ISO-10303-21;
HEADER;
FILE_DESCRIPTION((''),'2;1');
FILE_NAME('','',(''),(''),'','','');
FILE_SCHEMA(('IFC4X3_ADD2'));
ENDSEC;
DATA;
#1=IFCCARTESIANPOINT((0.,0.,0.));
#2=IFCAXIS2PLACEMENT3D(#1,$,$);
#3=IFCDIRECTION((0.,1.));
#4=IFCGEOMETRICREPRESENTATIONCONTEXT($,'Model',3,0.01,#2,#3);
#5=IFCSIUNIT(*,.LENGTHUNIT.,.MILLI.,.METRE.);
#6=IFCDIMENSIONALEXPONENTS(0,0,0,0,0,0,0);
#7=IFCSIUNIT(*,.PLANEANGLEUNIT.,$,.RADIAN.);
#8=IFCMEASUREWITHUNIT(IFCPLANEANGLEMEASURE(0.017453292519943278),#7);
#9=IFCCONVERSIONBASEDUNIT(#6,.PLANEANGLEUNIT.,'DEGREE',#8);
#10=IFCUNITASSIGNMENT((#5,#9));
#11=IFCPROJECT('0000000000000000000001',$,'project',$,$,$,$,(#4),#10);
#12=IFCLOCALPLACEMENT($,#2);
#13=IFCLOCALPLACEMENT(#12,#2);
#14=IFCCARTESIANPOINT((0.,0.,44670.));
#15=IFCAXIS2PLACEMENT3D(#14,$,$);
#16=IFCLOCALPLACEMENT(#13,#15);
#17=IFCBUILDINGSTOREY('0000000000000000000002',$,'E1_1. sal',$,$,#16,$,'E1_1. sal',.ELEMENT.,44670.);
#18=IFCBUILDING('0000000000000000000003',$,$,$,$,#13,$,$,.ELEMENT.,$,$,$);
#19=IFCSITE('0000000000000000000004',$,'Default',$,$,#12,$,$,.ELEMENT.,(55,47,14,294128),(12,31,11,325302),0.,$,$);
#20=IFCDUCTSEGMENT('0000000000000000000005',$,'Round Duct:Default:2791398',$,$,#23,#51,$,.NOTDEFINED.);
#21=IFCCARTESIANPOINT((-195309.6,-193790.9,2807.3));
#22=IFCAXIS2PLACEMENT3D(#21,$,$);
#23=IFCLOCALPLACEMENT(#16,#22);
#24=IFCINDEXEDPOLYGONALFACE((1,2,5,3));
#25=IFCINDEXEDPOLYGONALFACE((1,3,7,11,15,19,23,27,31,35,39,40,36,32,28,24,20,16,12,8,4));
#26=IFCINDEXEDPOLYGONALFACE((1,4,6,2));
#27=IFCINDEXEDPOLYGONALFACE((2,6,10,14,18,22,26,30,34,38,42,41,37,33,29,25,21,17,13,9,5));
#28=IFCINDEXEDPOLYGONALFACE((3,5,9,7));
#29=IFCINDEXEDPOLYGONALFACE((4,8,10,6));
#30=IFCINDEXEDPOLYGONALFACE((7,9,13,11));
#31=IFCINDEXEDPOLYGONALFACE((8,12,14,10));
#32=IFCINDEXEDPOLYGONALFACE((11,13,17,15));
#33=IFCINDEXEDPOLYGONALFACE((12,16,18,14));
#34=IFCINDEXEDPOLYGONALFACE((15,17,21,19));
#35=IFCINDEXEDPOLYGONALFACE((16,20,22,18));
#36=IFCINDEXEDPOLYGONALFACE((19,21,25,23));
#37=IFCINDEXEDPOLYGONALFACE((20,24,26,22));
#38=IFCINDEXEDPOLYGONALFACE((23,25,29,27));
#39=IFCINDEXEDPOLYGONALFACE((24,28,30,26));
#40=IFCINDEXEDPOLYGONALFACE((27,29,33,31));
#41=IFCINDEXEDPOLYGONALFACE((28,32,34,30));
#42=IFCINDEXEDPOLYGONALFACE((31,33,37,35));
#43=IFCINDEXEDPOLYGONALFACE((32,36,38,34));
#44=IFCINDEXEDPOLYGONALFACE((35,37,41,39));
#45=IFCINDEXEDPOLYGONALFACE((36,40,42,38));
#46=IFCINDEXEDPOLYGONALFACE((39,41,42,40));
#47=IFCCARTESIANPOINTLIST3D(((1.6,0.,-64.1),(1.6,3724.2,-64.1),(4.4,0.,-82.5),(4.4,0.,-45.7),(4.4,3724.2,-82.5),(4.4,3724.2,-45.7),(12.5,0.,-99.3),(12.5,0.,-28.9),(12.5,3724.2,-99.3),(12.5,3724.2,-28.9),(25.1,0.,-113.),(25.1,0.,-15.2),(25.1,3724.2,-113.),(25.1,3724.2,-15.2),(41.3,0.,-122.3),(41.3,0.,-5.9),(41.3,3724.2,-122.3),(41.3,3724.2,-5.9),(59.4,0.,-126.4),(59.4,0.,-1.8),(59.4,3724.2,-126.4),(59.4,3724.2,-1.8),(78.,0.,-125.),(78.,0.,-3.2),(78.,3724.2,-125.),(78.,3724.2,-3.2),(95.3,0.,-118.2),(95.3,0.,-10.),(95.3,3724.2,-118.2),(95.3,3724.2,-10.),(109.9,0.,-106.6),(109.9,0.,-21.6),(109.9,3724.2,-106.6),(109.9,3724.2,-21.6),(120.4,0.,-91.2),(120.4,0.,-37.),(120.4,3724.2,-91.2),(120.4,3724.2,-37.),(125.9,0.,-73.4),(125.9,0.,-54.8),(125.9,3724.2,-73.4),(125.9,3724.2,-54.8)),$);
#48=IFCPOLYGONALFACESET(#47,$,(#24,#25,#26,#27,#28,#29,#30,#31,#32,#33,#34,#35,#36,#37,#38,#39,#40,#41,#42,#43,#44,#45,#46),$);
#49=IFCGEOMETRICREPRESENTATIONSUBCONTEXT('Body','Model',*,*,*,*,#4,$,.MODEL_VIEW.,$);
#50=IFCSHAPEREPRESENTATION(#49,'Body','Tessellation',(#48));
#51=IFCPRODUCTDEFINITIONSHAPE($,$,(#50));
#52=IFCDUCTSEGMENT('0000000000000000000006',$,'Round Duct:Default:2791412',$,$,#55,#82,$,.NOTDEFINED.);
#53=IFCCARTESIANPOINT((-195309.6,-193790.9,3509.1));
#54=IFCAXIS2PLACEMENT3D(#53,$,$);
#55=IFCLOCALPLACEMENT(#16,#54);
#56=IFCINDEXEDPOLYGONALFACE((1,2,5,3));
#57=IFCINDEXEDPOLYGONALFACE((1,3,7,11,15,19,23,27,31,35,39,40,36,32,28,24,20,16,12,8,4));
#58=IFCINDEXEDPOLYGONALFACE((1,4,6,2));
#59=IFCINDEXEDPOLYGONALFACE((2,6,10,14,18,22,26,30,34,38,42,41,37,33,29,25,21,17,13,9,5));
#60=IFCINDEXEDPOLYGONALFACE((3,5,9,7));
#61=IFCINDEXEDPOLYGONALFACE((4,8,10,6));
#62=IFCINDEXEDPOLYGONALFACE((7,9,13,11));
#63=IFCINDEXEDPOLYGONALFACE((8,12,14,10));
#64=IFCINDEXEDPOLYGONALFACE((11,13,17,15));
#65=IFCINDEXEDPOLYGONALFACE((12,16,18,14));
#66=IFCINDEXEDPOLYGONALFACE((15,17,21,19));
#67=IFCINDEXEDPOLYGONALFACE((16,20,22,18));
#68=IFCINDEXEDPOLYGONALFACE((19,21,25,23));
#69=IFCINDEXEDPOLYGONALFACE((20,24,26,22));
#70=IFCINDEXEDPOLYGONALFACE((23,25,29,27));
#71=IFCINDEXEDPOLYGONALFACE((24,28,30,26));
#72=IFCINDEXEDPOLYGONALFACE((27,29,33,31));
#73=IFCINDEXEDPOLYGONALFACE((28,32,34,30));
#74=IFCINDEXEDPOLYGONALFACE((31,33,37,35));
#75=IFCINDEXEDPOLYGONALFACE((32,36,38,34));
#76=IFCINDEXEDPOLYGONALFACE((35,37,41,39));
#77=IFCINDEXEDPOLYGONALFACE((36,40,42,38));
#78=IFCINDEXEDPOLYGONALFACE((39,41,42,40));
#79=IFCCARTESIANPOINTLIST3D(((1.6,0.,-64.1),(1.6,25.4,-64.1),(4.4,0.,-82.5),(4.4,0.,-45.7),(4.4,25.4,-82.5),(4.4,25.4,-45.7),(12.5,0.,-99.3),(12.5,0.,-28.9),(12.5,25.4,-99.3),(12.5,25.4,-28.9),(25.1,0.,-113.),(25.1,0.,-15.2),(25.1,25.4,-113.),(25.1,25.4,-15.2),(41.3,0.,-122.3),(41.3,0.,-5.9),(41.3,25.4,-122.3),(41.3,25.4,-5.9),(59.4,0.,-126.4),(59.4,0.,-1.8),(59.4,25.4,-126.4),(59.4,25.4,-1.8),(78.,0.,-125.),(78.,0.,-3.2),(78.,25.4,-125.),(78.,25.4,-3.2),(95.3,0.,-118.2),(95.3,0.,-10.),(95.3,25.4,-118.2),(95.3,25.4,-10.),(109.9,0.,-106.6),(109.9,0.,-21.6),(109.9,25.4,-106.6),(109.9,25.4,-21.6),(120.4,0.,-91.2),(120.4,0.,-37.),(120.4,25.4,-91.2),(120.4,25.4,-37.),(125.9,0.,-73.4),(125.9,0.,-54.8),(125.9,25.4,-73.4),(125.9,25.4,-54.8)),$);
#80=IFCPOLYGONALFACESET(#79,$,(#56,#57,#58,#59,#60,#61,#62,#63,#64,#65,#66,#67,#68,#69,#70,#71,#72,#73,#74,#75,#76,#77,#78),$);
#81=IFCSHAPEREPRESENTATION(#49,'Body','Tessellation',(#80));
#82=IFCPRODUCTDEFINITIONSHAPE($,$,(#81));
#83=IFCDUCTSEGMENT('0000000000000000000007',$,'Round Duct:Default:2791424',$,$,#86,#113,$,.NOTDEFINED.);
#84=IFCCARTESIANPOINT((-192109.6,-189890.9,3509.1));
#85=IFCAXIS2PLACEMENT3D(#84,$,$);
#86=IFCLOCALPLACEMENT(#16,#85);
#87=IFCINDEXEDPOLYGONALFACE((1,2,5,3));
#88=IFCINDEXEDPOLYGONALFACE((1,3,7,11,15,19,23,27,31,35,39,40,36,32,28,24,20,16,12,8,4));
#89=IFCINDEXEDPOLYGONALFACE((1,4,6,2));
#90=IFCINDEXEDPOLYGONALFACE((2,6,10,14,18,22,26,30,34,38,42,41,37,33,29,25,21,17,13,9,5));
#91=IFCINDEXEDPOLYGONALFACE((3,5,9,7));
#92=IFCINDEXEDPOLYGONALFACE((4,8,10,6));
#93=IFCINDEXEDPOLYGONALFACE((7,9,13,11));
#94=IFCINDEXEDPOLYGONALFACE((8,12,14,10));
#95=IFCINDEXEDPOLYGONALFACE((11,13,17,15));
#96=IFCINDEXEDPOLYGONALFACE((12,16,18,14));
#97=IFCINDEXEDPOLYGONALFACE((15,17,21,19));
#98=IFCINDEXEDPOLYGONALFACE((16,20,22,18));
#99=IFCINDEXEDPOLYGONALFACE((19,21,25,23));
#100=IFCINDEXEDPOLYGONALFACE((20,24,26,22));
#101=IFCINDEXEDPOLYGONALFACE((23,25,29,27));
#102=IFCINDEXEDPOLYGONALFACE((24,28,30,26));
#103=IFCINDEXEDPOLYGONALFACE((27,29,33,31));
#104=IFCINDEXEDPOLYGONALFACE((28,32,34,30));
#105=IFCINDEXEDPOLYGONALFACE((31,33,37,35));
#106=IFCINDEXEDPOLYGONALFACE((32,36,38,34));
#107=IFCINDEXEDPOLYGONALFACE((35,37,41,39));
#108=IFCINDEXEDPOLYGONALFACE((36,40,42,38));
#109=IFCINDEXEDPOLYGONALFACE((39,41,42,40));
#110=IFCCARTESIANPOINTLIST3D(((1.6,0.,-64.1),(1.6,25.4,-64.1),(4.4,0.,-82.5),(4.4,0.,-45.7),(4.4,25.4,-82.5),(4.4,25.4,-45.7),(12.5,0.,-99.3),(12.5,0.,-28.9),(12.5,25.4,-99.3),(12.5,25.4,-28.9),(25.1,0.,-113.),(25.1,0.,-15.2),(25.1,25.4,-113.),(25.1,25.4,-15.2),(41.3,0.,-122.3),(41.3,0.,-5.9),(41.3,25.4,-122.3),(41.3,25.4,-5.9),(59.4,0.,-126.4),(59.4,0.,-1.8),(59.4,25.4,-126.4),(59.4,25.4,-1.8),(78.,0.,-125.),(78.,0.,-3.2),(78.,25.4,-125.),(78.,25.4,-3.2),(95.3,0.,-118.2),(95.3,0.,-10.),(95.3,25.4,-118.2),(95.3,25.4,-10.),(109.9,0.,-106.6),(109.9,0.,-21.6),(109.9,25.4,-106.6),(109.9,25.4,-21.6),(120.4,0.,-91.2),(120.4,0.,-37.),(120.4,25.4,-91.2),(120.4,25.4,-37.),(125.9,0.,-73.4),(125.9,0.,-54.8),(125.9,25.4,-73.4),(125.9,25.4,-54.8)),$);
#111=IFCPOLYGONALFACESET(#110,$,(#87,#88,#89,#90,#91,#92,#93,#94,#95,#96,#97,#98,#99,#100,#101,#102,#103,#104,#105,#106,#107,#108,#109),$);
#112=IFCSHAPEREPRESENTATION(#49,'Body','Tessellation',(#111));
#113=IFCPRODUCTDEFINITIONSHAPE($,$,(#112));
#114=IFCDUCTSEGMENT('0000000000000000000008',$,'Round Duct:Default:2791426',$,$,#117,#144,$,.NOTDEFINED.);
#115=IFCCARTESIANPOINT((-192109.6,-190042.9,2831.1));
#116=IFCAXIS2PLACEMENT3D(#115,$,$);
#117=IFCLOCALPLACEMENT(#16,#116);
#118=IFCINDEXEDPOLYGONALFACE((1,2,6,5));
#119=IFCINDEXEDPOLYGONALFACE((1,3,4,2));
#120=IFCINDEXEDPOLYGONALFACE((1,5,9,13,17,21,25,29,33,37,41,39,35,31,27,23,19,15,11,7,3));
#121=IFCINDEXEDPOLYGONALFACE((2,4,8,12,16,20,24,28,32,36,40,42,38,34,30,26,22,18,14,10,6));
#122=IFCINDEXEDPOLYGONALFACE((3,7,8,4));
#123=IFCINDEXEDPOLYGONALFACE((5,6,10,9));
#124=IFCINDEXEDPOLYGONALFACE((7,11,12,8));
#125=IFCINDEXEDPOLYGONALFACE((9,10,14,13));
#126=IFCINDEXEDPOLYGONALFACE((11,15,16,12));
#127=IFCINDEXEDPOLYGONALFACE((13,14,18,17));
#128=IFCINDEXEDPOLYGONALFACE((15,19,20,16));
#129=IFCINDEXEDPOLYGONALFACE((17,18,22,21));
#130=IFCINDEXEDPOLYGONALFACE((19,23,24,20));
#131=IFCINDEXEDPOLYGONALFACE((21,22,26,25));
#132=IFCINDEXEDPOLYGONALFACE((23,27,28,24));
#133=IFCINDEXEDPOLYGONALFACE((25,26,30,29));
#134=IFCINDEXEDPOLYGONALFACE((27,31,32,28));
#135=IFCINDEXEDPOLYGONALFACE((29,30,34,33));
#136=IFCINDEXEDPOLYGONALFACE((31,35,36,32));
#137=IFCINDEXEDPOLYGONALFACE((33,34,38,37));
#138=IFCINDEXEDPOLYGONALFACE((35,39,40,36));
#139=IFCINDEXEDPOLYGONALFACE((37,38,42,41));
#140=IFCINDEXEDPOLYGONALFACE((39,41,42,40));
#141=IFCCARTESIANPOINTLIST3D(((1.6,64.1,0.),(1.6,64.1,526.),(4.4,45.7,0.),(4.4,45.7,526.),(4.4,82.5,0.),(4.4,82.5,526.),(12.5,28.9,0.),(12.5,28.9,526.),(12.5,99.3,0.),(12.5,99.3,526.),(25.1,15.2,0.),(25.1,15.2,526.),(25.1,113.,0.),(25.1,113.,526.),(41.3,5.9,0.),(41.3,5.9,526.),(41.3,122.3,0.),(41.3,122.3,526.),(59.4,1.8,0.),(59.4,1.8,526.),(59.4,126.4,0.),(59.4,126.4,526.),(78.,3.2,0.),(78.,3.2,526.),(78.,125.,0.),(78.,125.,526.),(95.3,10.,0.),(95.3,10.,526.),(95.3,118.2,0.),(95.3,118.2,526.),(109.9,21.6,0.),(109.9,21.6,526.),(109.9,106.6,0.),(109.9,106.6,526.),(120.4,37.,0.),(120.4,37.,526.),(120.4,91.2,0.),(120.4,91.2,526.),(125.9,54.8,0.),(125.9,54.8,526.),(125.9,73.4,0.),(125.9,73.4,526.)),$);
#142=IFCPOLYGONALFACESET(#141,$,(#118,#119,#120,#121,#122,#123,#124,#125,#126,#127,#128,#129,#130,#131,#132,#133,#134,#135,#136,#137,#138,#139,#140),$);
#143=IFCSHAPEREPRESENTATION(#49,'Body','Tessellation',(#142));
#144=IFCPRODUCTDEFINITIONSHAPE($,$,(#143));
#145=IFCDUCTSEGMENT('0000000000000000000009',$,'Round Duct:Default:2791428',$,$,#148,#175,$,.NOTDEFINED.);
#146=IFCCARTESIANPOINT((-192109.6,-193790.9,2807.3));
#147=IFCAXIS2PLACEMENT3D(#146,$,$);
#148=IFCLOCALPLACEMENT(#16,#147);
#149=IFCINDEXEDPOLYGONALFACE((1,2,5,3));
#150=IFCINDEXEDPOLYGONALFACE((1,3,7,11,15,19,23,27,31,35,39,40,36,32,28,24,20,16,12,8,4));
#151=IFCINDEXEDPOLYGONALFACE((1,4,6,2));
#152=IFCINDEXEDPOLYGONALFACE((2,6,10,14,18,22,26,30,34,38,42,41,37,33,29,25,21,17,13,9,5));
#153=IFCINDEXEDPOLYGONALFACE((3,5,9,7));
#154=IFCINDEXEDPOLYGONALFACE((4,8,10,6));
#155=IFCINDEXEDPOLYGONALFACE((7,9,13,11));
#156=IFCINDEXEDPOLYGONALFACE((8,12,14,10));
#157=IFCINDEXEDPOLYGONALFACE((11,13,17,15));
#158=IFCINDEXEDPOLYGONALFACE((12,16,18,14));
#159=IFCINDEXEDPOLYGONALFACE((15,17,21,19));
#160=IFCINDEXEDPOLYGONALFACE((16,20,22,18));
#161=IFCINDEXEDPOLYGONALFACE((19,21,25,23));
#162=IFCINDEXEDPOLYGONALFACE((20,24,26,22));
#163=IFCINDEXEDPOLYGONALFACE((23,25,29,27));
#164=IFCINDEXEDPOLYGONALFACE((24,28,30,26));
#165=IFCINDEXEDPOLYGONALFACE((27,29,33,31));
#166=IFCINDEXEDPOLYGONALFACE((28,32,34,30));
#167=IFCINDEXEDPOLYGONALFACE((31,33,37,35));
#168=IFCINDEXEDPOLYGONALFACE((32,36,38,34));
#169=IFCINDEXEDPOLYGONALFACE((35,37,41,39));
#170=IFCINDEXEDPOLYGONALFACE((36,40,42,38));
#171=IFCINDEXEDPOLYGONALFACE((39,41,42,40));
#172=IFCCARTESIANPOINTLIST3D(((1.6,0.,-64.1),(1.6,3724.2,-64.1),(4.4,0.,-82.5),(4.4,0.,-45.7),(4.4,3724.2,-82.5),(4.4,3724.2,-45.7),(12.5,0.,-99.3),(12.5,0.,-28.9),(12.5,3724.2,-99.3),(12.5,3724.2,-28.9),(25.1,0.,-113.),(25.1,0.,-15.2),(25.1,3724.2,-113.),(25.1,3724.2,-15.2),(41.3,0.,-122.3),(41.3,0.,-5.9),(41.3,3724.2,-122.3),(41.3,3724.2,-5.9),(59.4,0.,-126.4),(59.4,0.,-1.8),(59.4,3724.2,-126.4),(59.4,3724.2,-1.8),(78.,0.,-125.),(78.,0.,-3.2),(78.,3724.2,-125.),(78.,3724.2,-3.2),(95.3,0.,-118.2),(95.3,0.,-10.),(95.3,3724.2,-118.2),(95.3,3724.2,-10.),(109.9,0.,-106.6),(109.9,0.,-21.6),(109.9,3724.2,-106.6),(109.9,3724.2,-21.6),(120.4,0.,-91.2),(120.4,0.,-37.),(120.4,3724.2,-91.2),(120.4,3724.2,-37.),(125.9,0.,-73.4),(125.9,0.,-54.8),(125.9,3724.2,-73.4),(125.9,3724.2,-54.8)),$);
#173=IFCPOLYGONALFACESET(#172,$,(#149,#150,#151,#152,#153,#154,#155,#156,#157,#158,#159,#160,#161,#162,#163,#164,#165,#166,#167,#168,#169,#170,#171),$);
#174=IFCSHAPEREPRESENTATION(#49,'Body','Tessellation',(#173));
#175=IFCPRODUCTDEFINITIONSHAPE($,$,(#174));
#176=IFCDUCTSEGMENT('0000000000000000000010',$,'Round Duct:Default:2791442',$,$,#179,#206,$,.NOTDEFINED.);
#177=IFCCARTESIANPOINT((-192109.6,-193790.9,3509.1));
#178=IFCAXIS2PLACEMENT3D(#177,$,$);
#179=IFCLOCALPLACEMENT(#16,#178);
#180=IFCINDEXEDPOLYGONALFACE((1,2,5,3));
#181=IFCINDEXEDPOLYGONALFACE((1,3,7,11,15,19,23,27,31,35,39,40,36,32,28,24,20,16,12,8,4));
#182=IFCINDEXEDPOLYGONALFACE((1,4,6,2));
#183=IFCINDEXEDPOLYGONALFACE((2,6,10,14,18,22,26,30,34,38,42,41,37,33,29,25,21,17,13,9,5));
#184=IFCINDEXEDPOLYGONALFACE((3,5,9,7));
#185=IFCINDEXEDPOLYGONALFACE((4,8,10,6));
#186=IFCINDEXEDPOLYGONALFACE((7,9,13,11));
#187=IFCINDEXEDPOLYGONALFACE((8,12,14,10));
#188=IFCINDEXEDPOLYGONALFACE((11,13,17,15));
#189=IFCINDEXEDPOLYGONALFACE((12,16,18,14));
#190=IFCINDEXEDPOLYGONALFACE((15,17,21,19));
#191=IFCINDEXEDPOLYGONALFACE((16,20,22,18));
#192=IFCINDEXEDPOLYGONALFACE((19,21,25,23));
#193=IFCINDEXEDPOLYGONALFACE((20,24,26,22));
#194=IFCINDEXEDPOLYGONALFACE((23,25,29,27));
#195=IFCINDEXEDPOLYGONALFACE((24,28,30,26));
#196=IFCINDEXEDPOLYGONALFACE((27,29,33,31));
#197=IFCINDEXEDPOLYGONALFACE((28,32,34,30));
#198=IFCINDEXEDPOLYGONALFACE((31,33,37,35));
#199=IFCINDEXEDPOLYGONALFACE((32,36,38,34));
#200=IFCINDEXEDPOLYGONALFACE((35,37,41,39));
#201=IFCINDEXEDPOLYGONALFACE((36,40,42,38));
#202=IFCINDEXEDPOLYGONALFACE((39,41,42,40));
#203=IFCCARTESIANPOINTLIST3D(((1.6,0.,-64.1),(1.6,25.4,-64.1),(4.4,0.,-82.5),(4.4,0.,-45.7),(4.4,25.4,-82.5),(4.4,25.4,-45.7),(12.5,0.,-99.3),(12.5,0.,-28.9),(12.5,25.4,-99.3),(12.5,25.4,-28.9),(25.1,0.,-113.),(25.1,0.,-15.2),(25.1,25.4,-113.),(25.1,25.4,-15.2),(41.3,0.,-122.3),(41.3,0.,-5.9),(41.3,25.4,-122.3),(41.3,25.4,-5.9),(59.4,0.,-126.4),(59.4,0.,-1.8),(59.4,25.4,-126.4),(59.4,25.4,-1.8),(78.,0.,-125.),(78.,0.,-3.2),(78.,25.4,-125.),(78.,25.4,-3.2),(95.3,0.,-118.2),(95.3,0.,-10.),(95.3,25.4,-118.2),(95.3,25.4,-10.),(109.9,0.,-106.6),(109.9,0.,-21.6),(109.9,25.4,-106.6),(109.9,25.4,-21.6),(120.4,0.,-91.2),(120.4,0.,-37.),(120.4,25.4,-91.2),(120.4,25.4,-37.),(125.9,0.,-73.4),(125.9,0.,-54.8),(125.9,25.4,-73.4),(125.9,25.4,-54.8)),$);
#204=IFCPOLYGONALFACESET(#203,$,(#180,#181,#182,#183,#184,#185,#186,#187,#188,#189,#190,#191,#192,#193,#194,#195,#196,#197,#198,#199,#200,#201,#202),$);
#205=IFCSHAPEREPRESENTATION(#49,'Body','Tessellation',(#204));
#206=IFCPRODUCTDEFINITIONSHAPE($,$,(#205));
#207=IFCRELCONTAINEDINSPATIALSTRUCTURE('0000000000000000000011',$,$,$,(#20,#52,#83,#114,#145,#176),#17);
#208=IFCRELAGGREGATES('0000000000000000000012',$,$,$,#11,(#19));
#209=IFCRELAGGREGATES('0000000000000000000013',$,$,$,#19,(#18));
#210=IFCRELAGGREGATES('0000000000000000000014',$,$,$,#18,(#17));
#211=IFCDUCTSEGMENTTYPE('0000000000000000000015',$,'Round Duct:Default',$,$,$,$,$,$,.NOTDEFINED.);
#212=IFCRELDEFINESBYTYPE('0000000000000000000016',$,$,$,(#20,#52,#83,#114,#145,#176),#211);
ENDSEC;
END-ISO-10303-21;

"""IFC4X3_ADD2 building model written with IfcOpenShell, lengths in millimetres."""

from ifc_helpers import new_model, entity, si_unit, converted_unit, direction, frame, frame_2d, origin, origin_2d_with_axis, place, context, subcontext, project, spatial, circle, extrude, type_object, element, save


model = new_model("IFC4X3_ADD2")

# Units and contexts
model_context = context("Model", 3, precision=0.01, world=origin(), true_north=direction((0.0, 1.0)))
body_context = subcontext(model_context, "Body", "Model", "MODEL_VIEW")
ifc_project = project(units=[si_unit("LENGTHUNIT", "METRE", prefix="MILLI"), converted_unit("PLANEANGLEUNIT", "DEGREE", entity("IfcPlaneAngleMeasure", 0.017453292519943278), si_unit("PLANEANGLEUNIT", "RADIAN"), dimensions=[0, 0, 0, 0, 0, 0, 0])], contexts=[model_context])

# Site, building, storey
site_placement = place(None, origin())
site = spatial("IfcSite", under=ifc_project, at=site_placement, Name="Default", CompositionType="ELEMENT", RefLatitude=(55, 47, 14, 294128), RefLongitude=(12, 31, 11, 325302), RefElevation=0.0)
building_placement = place(site_placement, origin())
building = spatial("IfcBuilding", under=site, at=building_placement, CompositionType="ELEMENT")
storey_placement = place(building_placement, frame((0.0, 0.0, 44670.0)))
storey = spatial("IfcBuildingStorey", under=building, at=storey_placement, Name="E1_1. sal", LongName="E1_1. sal", CompositionType="ELEMENT", Elevation=44670.0)

# Duct segments
duct_segment_type = type_object("IfcDuctSegmentType", Name="Round Duct:Default", PredefinedType="NOTDEFINED")
duct_segment_1_placement = place(storey_placement, frame((-195309.6, -193790.9, 2807.3)))
element("IfcDuctSegment", 1, at=duct_segment_1_placement, inside=storey, type_object=duct_segment_type, Name="Round Duct:Default:2791398", PredefinedType="NOTDEFINED", context=body_context, shape_type="SweptSolid", body=[
    extrude(circle(Radius=62.5, at=frame_2d((0.0, 0.0), x_axis=(1.0, 0.0))), frame((64.1, 0.0, -64.1), z_axis=(0.0, 1.0, 0.0), x_axis=(-1.0, 0.0, 0.0)), (0.0, 0.0, 1.0), 3724.2),
])
for number, where, name in (
    (2, (-195309.6, -193790.9, 3509.1), "Round Duct:Default:2791412"),
    (3, (-192109.6, -189890.9, 3509.1), "Round Duct:Default:2791424"),
):
    element("IfcDuctSegment", number, at=place(storey_placement, frame(where)), inside=storey, type_object=duct_segment_type, Name=name, PredefinedType="NOTDEFINED", context=body_context, shape_type="SweptSolid", body=[
        extrude(circle(Radius=62.5, at=origin_2d_with_axis()), frame((64.1, 0.0, -64.1), z_axis=(0.0, 1.0, 0.0), x_axis=(-1.0, 0.0, 0.0)), (0.0, 0.0, 1.0), 25.4),
    ])
duct_segment_2_placement = place(storey_placement, frame((-192109.6, -190042.9, 2831.1)))
element("IfcDuctSegment", 4, at=duct_segment_2_placement, inside=storey, type_object=duct_segment_type, Name="Round Duct:Default:2791426", PredefinedType="NOTDEFINED", context=body_context, shape_type="SweptSolid", body=[
    extrude(circle(Radius=62.5, at=frame_2d((0.0, 0.0), x_axis=(1.0, 0.0))), frame((64.1, 64.1, 0.0), z_axis=(0.0, 0.0, 1.0), x_axis=(-1.0, 0.0, 0.0)), (0.0, 0.0, 1.0), 526.0),
])
duct_segment_3_placement = place(storey_placement, frame((-192109.6, -193790.9, 2807.3)))
element("IfcDuctSegment", 5, at=duct_segment_3_placement, inside=storey, type_object=duct_segment_type, Name="Round Duct:Default:2791428", PredefinedType="NOTDEFINED", context=body_context, shape_type="SweptSolid", body=[
    extrude(circle(Radius=62.5, at=frame_2d((0.0, 0.0), x_axis=(1.0, 0.0))), frame((64.1, 0.0, -64.1), z_axis=(0.0, 1.0, 0.0), x_axis=(-1.0, 0.0, 0.0)), (0.0, 0.0, 1.0), 3724.2),
])
duct_segment_4_placement = place(storey_placement, frame((-192109.6, -193790.9, 3509.1)))
element("IfcDuctSegment", 6, at=duct_segment_4_placement, inside=storey, type_object=duct_segment_type, Name="Round Duct:Default:2791442", PredefinedType="NOTDEFINED", context=body_context, shape_type="SweptSolid", body=[
    extrude(circle(Radius=62.5, at=origin_2d_with_axis()), frame((64.1, 0.0, -64.1), z_axis=(0.0, 1.0, 0.0), x_axis=(-1.0, 0.0, 0.0)), (0.0, 0.0, 1.0), 25.4),
])

save(model, "model.ifc")
